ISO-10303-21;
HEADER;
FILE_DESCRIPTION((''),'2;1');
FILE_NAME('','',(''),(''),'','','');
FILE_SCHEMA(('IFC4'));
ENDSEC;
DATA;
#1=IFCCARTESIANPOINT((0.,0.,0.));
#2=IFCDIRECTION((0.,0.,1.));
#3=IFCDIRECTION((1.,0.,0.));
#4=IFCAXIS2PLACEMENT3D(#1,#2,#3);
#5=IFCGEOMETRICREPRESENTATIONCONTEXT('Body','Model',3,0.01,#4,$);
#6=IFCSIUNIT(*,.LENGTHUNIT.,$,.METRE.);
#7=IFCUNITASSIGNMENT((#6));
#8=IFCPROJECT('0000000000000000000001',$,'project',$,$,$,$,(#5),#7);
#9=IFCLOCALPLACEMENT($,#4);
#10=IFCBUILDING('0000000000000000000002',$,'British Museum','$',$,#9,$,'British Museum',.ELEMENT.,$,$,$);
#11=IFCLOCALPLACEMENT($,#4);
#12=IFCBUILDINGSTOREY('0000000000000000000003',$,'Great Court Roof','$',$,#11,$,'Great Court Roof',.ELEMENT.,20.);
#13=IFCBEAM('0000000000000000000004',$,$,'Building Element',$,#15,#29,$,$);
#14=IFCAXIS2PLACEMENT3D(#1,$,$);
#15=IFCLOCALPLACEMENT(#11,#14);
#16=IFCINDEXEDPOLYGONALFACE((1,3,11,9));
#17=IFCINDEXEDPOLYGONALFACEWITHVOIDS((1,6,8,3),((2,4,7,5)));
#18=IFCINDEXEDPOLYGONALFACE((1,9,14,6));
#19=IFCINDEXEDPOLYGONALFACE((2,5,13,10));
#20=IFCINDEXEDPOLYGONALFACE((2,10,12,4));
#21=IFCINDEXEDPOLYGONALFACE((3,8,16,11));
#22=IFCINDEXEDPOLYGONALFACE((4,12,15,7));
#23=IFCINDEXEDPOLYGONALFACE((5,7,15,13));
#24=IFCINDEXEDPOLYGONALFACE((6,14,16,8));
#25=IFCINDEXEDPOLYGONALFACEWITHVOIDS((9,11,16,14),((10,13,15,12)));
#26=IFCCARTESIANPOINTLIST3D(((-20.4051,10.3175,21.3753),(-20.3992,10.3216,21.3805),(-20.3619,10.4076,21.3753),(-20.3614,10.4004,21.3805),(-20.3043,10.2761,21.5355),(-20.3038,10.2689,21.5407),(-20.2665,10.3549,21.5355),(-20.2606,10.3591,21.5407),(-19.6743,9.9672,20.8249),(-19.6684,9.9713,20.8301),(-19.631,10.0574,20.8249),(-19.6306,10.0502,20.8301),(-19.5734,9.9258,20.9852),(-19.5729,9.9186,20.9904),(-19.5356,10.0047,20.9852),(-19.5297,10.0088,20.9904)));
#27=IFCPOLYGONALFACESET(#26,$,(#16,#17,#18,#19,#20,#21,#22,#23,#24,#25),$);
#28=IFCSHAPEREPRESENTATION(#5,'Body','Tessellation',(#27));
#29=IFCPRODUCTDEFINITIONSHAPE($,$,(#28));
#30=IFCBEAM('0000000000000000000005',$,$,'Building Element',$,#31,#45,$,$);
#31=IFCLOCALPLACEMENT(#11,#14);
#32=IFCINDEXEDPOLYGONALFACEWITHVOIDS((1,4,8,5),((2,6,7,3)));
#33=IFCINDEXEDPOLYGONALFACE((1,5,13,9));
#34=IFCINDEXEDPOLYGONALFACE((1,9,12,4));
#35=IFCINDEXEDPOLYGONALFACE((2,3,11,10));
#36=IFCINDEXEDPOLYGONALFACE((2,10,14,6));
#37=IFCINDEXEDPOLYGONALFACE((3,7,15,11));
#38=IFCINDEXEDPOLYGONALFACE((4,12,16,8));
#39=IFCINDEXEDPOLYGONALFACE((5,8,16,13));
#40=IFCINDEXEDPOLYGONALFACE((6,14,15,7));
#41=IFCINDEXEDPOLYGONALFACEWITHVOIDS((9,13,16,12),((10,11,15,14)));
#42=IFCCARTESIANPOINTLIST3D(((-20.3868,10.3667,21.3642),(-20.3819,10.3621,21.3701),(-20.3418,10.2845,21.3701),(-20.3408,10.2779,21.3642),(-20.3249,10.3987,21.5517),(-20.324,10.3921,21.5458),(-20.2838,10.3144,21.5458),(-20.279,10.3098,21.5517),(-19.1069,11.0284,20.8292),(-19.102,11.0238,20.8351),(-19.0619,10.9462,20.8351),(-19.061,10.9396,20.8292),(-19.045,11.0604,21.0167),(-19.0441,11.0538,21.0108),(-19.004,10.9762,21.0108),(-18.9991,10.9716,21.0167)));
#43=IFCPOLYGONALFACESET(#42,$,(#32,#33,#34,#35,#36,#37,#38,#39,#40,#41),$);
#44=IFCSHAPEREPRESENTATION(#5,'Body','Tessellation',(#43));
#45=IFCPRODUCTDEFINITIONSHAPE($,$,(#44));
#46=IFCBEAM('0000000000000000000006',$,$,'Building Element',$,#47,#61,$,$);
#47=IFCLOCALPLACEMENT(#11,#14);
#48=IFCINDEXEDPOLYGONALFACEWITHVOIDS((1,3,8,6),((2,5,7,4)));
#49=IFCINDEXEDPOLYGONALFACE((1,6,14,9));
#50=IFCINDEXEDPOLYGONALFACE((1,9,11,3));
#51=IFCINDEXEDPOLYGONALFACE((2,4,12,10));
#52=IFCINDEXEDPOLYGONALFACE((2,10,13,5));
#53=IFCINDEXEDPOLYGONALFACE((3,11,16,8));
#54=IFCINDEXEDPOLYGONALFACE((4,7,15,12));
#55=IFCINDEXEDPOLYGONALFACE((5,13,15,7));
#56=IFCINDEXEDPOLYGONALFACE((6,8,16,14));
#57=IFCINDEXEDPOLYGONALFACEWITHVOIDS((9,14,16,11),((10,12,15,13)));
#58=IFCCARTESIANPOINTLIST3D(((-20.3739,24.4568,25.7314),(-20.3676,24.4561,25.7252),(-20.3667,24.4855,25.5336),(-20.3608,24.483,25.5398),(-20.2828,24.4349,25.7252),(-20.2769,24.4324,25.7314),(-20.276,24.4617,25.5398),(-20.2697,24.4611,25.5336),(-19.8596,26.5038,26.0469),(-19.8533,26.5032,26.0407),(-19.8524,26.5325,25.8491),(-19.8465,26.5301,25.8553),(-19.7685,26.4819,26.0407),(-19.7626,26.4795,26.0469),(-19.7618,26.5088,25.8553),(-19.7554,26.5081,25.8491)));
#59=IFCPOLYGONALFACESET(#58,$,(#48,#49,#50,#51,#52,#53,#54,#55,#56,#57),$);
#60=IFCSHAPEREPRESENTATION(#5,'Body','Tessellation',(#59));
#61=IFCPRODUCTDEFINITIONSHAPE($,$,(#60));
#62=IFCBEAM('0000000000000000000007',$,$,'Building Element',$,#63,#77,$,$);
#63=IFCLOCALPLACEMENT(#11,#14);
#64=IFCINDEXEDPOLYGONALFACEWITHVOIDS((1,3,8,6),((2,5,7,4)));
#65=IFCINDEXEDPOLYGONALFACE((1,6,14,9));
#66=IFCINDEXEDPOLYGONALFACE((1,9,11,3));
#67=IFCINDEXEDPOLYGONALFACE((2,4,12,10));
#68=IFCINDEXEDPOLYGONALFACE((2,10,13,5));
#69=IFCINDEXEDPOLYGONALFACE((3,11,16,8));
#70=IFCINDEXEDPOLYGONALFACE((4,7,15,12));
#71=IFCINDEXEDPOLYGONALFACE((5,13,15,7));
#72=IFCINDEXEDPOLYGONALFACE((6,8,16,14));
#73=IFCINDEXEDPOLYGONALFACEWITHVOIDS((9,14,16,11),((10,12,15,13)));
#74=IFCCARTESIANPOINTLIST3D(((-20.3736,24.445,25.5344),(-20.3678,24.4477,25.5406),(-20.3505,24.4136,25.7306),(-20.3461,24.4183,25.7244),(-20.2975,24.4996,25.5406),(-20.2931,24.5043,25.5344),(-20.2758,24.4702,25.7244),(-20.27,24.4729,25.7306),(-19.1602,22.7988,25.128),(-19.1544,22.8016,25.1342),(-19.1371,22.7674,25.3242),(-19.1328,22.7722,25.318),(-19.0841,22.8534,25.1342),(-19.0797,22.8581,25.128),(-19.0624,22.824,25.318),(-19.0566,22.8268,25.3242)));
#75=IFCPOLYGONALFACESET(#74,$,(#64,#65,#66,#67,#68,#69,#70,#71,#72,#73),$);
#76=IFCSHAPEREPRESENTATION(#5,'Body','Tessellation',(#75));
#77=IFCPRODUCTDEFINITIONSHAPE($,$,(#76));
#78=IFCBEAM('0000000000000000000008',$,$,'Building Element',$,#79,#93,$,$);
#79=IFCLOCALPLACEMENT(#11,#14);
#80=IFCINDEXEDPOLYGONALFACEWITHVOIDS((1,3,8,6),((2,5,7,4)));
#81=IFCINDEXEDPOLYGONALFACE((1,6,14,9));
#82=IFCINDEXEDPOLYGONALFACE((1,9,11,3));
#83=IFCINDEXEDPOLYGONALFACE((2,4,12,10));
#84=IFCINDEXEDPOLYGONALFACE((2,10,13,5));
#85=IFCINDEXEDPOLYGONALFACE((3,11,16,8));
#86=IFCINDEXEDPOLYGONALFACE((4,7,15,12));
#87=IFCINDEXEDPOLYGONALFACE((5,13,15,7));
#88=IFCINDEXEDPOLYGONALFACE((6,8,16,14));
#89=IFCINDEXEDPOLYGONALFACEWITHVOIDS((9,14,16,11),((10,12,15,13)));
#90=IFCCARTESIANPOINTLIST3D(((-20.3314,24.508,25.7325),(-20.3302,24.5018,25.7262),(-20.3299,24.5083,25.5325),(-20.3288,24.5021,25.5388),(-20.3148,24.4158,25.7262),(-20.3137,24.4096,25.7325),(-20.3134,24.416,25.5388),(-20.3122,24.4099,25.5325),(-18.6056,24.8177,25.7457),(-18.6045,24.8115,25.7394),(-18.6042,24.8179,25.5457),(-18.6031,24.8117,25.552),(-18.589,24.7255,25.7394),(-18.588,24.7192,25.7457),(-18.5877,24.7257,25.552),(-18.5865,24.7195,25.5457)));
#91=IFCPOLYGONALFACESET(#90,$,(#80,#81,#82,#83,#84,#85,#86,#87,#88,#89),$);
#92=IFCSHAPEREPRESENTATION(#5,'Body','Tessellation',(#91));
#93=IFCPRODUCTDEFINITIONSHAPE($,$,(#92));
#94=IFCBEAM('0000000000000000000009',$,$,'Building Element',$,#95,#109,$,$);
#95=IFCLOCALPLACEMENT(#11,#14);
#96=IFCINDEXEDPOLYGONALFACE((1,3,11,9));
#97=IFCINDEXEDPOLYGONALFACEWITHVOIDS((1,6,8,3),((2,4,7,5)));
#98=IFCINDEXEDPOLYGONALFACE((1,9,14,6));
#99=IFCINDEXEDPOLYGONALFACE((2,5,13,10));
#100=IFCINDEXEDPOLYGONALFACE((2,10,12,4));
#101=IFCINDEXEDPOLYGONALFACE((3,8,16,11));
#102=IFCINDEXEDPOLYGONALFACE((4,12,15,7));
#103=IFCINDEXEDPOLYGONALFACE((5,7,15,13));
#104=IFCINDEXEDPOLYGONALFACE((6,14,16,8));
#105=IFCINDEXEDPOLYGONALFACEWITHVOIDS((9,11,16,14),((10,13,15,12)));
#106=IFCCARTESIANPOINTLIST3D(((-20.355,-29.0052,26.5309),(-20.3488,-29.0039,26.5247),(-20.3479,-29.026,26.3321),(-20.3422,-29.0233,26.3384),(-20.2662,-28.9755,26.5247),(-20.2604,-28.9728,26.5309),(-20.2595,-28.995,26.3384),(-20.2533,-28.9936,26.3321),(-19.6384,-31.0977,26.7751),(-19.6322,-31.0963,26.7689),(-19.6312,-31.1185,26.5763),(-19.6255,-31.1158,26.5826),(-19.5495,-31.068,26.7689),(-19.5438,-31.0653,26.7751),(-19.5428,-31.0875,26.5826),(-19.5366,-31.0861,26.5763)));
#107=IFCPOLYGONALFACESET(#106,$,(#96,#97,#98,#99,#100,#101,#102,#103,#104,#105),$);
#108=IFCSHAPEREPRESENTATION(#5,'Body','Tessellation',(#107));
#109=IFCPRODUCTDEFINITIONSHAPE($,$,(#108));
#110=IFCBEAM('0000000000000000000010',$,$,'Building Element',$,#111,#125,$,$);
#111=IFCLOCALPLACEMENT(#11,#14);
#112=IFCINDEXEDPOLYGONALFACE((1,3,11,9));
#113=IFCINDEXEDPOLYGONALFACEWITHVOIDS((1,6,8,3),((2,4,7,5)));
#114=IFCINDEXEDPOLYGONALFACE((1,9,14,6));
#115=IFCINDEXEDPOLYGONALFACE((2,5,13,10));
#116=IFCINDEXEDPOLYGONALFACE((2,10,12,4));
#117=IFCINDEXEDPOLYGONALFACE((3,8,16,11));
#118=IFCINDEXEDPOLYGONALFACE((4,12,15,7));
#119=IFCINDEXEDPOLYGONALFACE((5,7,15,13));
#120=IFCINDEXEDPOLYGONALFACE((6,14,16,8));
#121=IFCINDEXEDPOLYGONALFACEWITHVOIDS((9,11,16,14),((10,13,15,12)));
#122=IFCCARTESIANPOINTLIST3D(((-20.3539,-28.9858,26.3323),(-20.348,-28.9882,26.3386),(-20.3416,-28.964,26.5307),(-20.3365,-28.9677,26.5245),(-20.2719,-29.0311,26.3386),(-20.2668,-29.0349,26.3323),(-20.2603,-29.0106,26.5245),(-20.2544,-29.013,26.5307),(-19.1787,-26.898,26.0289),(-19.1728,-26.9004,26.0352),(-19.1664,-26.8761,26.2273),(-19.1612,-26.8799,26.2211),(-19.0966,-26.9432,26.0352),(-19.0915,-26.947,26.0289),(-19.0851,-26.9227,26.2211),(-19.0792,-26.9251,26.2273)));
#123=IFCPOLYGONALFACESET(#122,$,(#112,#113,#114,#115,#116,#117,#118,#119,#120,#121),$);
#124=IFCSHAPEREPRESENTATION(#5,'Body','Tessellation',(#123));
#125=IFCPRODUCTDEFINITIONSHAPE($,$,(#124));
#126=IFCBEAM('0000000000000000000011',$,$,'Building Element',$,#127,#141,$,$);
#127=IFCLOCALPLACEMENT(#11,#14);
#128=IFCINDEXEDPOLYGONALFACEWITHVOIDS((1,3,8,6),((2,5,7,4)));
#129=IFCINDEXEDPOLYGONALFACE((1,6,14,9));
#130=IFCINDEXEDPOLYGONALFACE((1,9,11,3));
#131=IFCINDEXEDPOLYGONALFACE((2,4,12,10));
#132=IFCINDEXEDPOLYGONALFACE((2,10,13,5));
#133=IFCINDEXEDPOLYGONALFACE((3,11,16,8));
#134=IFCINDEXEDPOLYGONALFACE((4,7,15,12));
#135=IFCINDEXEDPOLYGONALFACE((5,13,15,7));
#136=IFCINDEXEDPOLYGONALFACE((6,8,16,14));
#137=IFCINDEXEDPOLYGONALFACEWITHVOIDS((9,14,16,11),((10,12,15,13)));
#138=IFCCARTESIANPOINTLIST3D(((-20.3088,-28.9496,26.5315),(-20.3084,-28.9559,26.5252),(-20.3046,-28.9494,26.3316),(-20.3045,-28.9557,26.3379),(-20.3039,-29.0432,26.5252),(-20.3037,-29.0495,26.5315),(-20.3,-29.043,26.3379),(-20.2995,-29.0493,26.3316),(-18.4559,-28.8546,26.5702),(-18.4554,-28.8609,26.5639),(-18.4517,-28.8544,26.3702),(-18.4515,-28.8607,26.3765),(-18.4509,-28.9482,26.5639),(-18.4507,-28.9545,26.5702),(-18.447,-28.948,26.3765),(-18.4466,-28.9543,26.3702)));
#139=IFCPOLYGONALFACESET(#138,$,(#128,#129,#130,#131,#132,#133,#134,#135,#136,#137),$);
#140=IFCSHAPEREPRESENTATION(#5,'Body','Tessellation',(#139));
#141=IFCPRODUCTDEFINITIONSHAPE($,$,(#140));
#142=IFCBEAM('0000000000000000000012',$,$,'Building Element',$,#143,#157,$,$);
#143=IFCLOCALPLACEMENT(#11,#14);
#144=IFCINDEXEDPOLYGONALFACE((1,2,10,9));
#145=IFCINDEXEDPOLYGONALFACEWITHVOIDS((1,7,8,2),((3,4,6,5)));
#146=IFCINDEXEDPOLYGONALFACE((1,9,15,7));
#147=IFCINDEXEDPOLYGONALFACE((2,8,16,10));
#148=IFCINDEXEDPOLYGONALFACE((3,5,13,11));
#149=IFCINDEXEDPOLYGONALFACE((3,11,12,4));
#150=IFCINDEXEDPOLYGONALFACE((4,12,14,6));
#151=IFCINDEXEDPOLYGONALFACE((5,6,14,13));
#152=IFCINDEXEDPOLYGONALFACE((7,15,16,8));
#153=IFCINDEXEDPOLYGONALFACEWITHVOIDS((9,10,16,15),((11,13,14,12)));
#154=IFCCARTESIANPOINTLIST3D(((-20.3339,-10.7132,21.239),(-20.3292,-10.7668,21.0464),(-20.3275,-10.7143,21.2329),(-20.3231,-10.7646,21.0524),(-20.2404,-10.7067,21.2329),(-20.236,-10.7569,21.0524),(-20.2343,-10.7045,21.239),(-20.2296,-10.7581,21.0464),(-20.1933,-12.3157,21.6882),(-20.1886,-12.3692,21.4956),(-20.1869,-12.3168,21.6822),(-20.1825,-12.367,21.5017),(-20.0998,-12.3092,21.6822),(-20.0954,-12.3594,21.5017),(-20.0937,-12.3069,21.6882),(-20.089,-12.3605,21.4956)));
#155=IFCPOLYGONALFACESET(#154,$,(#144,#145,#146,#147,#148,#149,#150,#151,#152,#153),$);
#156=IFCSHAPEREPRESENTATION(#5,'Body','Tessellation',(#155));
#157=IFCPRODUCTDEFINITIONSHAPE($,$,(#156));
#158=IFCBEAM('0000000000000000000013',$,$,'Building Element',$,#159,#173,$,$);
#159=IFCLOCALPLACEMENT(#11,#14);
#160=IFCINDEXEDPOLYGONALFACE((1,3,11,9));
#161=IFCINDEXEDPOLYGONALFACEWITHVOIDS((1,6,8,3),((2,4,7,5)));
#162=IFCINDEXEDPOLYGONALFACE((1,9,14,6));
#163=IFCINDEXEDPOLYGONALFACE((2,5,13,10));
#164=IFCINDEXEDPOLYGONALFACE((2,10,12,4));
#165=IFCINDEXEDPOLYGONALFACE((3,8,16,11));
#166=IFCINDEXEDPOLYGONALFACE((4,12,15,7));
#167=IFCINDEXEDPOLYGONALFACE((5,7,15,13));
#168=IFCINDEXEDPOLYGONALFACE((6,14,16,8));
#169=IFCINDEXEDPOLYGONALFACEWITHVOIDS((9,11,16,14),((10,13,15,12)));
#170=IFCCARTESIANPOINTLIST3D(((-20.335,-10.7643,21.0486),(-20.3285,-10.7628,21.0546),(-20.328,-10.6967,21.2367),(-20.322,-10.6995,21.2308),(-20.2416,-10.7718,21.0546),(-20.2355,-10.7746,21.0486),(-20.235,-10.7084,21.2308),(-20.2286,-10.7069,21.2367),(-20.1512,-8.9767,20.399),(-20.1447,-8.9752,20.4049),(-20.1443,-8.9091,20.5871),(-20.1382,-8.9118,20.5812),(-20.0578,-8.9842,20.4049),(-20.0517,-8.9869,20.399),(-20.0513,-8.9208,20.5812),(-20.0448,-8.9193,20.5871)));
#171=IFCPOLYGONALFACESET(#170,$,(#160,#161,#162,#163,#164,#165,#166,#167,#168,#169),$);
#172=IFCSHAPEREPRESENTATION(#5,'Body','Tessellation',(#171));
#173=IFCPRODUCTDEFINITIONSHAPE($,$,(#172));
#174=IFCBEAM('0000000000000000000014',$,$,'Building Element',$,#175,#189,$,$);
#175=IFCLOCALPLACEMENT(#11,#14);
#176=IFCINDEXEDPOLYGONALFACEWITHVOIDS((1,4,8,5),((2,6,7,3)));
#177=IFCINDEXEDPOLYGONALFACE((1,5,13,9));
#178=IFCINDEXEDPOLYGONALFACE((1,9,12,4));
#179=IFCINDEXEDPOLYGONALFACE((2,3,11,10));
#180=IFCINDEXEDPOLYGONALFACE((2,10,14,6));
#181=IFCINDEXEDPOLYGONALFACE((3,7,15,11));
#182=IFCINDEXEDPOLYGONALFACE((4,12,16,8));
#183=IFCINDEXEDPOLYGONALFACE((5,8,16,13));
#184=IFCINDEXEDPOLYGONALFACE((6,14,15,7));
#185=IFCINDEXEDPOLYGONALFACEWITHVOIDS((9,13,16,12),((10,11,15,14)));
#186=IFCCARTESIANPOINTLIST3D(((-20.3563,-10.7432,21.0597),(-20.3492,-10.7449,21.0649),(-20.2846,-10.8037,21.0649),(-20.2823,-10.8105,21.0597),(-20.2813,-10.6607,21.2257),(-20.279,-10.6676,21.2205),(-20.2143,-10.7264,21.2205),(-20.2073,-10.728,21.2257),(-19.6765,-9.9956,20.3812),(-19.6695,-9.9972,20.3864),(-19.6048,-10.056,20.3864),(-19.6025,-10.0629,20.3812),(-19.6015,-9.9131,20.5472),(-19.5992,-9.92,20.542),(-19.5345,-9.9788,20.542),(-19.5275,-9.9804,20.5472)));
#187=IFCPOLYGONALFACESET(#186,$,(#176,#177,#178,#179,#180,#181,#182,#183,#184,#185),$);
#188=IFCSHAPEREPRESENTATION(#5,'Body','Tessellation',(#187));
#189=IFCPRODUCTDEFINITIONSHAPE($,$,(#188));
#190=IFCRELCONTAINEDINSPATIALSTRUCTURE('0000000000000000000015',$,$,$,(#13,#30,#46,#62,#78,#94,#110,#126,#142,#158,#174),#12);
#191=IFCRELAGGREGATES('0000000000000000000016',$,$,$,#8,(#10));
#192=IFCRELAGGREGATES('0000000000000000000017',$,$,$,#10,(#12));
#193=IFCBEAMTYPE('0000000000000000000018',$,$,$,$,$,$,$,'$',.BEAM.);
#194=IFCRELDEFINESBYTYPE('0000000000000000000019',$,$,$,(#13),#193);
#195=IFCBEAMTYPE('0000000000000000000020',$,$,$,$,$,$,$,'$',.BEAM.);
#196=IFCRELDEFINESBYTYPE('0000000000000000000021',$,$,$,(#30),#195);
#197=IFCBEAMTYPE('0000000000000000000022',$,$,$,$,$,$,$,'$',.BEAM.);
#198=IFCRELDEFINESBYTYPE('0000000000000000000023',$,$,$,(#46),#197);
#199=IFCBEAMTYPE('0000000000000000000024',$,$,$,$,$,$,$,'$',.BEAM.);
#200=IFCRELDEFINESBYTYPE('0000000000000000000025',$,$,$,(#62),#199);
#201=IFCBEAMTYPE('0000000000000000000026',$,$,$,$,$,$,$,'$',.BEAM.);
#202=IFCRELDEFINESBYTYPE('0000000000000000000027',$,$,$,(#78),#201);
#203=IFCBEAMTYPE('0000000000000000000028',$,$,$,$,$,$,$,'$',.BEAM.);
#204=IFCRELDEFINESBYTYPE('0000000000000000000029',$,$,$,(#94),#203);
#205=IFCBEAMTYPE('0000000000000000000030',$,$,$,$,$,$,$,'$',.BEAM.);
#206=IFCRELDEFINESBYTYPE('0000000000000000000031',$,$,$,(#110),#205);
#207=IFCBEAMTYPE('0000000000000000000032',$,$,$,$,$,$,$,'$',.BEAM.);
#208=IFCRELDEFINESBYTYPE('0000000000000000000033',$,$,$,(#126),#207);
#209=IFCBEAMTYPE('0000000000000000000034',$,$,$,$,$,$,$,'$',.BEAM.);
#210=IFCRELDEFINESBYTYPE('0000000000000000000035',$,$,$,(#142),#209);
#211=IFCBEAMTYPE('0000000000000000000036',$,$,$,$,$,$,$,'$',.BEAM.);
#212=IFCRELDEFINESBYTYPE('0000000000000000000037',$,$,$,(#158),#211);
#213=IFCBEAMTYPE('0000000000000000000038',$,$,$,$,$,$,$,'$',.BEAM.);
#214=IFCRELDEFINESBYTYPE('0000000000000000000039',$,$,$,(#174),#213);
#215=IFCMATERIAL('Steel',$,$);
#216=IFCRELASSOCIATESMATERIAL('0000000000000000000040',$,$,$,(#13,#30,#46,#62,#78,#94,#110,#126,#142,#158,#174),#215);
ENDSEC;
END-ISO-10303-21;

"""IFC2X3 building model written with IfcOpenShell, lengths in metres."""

from ifc_helpers import new_model, si_unit, frame, origin_with_axes, origin_2d, place, context, project, spatial, hollow_rectangle, extrude, material, type_object, element, save


model = new_model("IFC2X3")

# Units and contexts
model_context = context("Model", 3, precision=0.01, world=origin_with_axes(), identifier="Body")
ifc_project = project(units=[si_unit("LENGTHUNIT", "METRE")], contexts=[model_context])

# Building, storey
building_placement = place(None, origin_with_axes())
building = spatial("IfcBuilding", under=ifc_project, at=building_placement, Name="British Museum", Description="$", LongName="British Museum", CompositionType="ELEMENT")
storey_placement = place(None, origin_with_axes())
storey = spatial("IfcBuildingStorey", under=building, at=storey_placement, Name="Great Court Roof", Description="$", LongName="Great Court Roof", CompositionType="ELEMENT", Elevation=20.0)

# Beams
ifc_material = material(Name="Steel")
beam_type_1 = type_object("IfcBeamType", ElementType="$", PredefinedType="BEAM")
beam_1_placement = place(None, origin_with_axes())
element("IfcBeam", 1, at=beam_1_placement, inside=storey, type_object=beam_type_1, material=ifc_material, Description="Building Element", context=model_context, shape_type="SweptSolid", body=[
    extrude(hollow_rectangle(XDim=0.1, YDim=0.2, WallThickness=0.0063, InnerFilletRadius=-0.0063, OuterFilletRadius=0.0, at=origin_2d()), frame((-20.3329, 10.3383, 21.458), z_axis=(0.746038, -0.357541, -0.561775), x_axis=(0.432184, 0.901786, 0.0)), (0.0, 0.0, 1.0), 0.9797),
])
beam_type_2 = type_object("IfcBeamType", ElementType="$", PredefinedType="BEAM")
beam_2_placement = place(None, origin_with_axes())
element("IfcBeam", 2, at=beam_2_placement, inside=storey, type_object=beam_type_2, material=ifc_material, Description="Building Element", context=model_context, shape_type="SweptSolid", body=[
    extrude(hollow_rectangle(XDim=0.1, YDim=0.2, WallThickness=0.0063, InnerFilletRadius=-0.0063, OuterFilletRadius=0.0, at=origin_2d()), frame((-20.3329, 10.3383, 21.458), z_axis=(0.832731, 0.430546, -0.348121), x_axis=(-0.459274, 0.888295, 0.0)), (0.0, 0.0, 1.0), 1.537),
])
beam_type_3 = type_object("IfcBeamType", ElementType="$", PredefinedType="BEAM")
beam_3_placement = place(None, origin_with_axes())
element("IfcBeam", 3, at=beam_3_placement, inside=storey, type_object=beam_type_3, material=ifc_material, Description="Building Element", context=model_context, shape_type="SweptSolid", body=[
    extrude(hollow_rectangle(XDim=0.1, YDim=0.2, WallThickness=0.0063, InnerFilletRadius=-0.0063, OuterFilletRadius=0.0, at=origin_2d()), frame((-20.3218, 24.4589, 25.6325), z_axis=(0.240984, 0.959205, 0.147828), x_axis=(-0.96986, 0.243661, 0.0)), (0.0, 0.0, 1.0), 2.1341),
])
beam_type_4 = type_object("IfcBeamType", ElementType="$", PredefinedType="BEAM")
beam_4_placement = place(None, origin_with_axes())
element("IfcBeam", 4, at=beam_4_placement, inside=storey, type_object=beam_type_4, material=ifc_material, Description="Building Element", context=model_context, shape_type="SweptSolid", body=[
    extrude(hollow_rectangle(XDim=0.1, YDim=0.2, WallThickness=0.0063, InnerFilletRadius=-0.0063, OuterFilletRadius=0.0, at=origin_2d()), frame((-20.3218, 24.4589, 25.6325), z_axis=(0.581954, -0.789519, -0.194907), x_axis=(0.804957, 0.593333, 0.0)), (0.0, 0.0, 1.0), 2.085),
])
beam_type_5 = type_object("IfcBeamType", ElementType="$", PredefinedType="BEAM")
beam_5_placement = place(None, origin_with_axes())
element("IfcBeam", 5, at=beam_5_placement, inside=storey, type_object=beam_type_5, material=ifc_material, Description="Building Element", context=model_context, shape_type="SweptSolid", body=[
    extrude(hollow_rectangle(XDim=0.1, YDim=0.2, WallThickness=0.0063, InnerFilletRadius=-0.0063, OuterFilletRadius=0.0, at=origin_2d()), frame((-20.3218, 24.4589, 25.6325), z_axis=(0.984253, 0.176608, 0.007515), x_axis=(-0.176613, 0.98428, 0.0)), (0.0, 0.0, 1.0), 1.7533),
])
beam_type_6 = type_object("IfcBeamType", ElementType="$", PredefinedType="BEAM")
beam_6_placement = place(None, origin_with_axes())
element("IfcBeam", 6, at=beam_6_placement, inside=storey, type_object=beam_type_6, material=ifc_material, Description="Building Element", context=model_context, shape_type="SweptSolid", body=[
    extrude(hollow_rectangle(XDim=0.1, YDim=0.2, WallThickness=0.0063, InnerFilletRadius=-0.0063, OuterFilletRadius=0.0, at=origin_2d()), frame((-20.3042, -28.9994, 26.4315), z_axis=(0.322065, -0.940335, 0.109744), x_axis=(0.94605, 0.324022, 0.0)), (0.0, 0.0, 1.0), 2.2252),
])
beam_type_7 = type_object("IfcBeamType", ElementType="$", PredefinedType="BEAM")
beam_7_placement = place(None, origin_with_axes())
element("IfcBeam", 7, at=beam_7_placement, inside=storey, type_object=beam_type_7, material=ifc_material, Description="Building Element", context=model_context, shape_type="SweptSolid", body=[
    extrude(hollow_rectangle(XDim=0.1, YDim=0.2, WallThickness=0.0063, InnerFilletRadius=-0.0063, OuterFilletRadius=0.0, at=origin_2d()), frame((-20.3042, -28.9994, 26.4315), z_axis=(0.486628, 0.86453, -0.125627), x_axis=(-0.871434, 0.490514, 0.0)), (0.0, 0.0, 1.0), 2.415),
])
beam_type_8 = type_object("IfcBeamType", ElementType="$", PredefinedType="BEAM")
beam_8_placement = place(None, origin_with_axes())
element("IfcBeam", 8, at=beam_8_placement, inside=storey, type_object=beam_type_8, material=ifc_material, Description="Building Element", context=model_context, shape_type="SweptSolid", body=[
    extrude(hollow_rectangle(XDim=0.1, YDim=0.2, WallThickness=0.0063, InnerFilletRadius=-0.0063, OuterFilletRadius=0.0, at=origin_2d()), frame((-20.3042, -28.9994, 26.4315), z_axis=(0.998472, 0.051185, 0.02085), x_axis=(-0.051196, 0.998689, 0.0)), (0.0, 0.0, 1.0), 1.8558),
])
beam_type_9 = type_object("IfcBeamType", ElementType="$", PredefinedType="BEAM")
beam_9_placement = place(None, origin_with_axes())
element("IfcBeam", 9, at=beam_9_placement, inside=storey, type_object=beam_type_9, material=ifc_material, Description="Building Element", context=model_context, shape_type="SweptSolid", body=[
    extrude(hollow_rectangle(XDim=0.1, YDim=0.2, WallThickness=0.0063, InnerFilletRadius=-0.0063, OuterFilletRadius=0.0, at=origin_2d()), frame((-20.2818, -10.7356, 21.1427), z_axis=(0.084198, -0.959459, 0.268979), x_axis=(0.996172, 0.08742, 0.0)), (0.0, 0.0, 1.0), 1.6702),
])
beam_type_10 = type_object("IfcBeamType", ElementType="$", PredefinedType="BEAM")
beam_10_placement = place(None, origin_with_axes())
element("IfcBeam", 10, at=beam_10_placement, inside=storey, type_object=beam_type_10, material=ifc_material, Description="Building Element", context=model_context, shape_type="SweptSolid", body=[
    extrude(hollow_rectangle(XDim=0.1, YDim=0.2, WallThickness=0.0063, InnerFilletRadius=-0.0063, OuterFilletRadius=0.0, at=origin_2d()), frame((-20.2818, -10.7356, 21.1427), z_axis=(0.09617, 0.935506, -0.339971), x_axis=(-0.994758, 0.102261, 0.0)), (0.0, 0.0, 1.0), 1.9109),
])
beam_type_11 = type_object("IfcBeamType", ElementType="$", PredefinedType="BEAM")
beam_11_placement = place(None, origin_with_axes())
element("IfcBeam", 11, at=beam_11_placement, inside=storey, type_object=beam_type_11, material=ifc_material, Description="Building Element", context=model_context, shape_type="SweptSolid", body=[
    extrude(hollow_rectangle(XDim=0.1, YDim=0.2, WallThickness=0.0063, InnerFilletRadius=-0.0063, OuterFilletRadius=0.0, at=origin_2d()), frame((-20.2818, -10.7356, 21.1427), z_axis=(0.558513, 0.614267, -0.55744), x_axis=(-0.739887, 0.672731, 0.0)), (0.0, 0.0, 1.0), 1.2171),
])

save(model, "model.ifc")
